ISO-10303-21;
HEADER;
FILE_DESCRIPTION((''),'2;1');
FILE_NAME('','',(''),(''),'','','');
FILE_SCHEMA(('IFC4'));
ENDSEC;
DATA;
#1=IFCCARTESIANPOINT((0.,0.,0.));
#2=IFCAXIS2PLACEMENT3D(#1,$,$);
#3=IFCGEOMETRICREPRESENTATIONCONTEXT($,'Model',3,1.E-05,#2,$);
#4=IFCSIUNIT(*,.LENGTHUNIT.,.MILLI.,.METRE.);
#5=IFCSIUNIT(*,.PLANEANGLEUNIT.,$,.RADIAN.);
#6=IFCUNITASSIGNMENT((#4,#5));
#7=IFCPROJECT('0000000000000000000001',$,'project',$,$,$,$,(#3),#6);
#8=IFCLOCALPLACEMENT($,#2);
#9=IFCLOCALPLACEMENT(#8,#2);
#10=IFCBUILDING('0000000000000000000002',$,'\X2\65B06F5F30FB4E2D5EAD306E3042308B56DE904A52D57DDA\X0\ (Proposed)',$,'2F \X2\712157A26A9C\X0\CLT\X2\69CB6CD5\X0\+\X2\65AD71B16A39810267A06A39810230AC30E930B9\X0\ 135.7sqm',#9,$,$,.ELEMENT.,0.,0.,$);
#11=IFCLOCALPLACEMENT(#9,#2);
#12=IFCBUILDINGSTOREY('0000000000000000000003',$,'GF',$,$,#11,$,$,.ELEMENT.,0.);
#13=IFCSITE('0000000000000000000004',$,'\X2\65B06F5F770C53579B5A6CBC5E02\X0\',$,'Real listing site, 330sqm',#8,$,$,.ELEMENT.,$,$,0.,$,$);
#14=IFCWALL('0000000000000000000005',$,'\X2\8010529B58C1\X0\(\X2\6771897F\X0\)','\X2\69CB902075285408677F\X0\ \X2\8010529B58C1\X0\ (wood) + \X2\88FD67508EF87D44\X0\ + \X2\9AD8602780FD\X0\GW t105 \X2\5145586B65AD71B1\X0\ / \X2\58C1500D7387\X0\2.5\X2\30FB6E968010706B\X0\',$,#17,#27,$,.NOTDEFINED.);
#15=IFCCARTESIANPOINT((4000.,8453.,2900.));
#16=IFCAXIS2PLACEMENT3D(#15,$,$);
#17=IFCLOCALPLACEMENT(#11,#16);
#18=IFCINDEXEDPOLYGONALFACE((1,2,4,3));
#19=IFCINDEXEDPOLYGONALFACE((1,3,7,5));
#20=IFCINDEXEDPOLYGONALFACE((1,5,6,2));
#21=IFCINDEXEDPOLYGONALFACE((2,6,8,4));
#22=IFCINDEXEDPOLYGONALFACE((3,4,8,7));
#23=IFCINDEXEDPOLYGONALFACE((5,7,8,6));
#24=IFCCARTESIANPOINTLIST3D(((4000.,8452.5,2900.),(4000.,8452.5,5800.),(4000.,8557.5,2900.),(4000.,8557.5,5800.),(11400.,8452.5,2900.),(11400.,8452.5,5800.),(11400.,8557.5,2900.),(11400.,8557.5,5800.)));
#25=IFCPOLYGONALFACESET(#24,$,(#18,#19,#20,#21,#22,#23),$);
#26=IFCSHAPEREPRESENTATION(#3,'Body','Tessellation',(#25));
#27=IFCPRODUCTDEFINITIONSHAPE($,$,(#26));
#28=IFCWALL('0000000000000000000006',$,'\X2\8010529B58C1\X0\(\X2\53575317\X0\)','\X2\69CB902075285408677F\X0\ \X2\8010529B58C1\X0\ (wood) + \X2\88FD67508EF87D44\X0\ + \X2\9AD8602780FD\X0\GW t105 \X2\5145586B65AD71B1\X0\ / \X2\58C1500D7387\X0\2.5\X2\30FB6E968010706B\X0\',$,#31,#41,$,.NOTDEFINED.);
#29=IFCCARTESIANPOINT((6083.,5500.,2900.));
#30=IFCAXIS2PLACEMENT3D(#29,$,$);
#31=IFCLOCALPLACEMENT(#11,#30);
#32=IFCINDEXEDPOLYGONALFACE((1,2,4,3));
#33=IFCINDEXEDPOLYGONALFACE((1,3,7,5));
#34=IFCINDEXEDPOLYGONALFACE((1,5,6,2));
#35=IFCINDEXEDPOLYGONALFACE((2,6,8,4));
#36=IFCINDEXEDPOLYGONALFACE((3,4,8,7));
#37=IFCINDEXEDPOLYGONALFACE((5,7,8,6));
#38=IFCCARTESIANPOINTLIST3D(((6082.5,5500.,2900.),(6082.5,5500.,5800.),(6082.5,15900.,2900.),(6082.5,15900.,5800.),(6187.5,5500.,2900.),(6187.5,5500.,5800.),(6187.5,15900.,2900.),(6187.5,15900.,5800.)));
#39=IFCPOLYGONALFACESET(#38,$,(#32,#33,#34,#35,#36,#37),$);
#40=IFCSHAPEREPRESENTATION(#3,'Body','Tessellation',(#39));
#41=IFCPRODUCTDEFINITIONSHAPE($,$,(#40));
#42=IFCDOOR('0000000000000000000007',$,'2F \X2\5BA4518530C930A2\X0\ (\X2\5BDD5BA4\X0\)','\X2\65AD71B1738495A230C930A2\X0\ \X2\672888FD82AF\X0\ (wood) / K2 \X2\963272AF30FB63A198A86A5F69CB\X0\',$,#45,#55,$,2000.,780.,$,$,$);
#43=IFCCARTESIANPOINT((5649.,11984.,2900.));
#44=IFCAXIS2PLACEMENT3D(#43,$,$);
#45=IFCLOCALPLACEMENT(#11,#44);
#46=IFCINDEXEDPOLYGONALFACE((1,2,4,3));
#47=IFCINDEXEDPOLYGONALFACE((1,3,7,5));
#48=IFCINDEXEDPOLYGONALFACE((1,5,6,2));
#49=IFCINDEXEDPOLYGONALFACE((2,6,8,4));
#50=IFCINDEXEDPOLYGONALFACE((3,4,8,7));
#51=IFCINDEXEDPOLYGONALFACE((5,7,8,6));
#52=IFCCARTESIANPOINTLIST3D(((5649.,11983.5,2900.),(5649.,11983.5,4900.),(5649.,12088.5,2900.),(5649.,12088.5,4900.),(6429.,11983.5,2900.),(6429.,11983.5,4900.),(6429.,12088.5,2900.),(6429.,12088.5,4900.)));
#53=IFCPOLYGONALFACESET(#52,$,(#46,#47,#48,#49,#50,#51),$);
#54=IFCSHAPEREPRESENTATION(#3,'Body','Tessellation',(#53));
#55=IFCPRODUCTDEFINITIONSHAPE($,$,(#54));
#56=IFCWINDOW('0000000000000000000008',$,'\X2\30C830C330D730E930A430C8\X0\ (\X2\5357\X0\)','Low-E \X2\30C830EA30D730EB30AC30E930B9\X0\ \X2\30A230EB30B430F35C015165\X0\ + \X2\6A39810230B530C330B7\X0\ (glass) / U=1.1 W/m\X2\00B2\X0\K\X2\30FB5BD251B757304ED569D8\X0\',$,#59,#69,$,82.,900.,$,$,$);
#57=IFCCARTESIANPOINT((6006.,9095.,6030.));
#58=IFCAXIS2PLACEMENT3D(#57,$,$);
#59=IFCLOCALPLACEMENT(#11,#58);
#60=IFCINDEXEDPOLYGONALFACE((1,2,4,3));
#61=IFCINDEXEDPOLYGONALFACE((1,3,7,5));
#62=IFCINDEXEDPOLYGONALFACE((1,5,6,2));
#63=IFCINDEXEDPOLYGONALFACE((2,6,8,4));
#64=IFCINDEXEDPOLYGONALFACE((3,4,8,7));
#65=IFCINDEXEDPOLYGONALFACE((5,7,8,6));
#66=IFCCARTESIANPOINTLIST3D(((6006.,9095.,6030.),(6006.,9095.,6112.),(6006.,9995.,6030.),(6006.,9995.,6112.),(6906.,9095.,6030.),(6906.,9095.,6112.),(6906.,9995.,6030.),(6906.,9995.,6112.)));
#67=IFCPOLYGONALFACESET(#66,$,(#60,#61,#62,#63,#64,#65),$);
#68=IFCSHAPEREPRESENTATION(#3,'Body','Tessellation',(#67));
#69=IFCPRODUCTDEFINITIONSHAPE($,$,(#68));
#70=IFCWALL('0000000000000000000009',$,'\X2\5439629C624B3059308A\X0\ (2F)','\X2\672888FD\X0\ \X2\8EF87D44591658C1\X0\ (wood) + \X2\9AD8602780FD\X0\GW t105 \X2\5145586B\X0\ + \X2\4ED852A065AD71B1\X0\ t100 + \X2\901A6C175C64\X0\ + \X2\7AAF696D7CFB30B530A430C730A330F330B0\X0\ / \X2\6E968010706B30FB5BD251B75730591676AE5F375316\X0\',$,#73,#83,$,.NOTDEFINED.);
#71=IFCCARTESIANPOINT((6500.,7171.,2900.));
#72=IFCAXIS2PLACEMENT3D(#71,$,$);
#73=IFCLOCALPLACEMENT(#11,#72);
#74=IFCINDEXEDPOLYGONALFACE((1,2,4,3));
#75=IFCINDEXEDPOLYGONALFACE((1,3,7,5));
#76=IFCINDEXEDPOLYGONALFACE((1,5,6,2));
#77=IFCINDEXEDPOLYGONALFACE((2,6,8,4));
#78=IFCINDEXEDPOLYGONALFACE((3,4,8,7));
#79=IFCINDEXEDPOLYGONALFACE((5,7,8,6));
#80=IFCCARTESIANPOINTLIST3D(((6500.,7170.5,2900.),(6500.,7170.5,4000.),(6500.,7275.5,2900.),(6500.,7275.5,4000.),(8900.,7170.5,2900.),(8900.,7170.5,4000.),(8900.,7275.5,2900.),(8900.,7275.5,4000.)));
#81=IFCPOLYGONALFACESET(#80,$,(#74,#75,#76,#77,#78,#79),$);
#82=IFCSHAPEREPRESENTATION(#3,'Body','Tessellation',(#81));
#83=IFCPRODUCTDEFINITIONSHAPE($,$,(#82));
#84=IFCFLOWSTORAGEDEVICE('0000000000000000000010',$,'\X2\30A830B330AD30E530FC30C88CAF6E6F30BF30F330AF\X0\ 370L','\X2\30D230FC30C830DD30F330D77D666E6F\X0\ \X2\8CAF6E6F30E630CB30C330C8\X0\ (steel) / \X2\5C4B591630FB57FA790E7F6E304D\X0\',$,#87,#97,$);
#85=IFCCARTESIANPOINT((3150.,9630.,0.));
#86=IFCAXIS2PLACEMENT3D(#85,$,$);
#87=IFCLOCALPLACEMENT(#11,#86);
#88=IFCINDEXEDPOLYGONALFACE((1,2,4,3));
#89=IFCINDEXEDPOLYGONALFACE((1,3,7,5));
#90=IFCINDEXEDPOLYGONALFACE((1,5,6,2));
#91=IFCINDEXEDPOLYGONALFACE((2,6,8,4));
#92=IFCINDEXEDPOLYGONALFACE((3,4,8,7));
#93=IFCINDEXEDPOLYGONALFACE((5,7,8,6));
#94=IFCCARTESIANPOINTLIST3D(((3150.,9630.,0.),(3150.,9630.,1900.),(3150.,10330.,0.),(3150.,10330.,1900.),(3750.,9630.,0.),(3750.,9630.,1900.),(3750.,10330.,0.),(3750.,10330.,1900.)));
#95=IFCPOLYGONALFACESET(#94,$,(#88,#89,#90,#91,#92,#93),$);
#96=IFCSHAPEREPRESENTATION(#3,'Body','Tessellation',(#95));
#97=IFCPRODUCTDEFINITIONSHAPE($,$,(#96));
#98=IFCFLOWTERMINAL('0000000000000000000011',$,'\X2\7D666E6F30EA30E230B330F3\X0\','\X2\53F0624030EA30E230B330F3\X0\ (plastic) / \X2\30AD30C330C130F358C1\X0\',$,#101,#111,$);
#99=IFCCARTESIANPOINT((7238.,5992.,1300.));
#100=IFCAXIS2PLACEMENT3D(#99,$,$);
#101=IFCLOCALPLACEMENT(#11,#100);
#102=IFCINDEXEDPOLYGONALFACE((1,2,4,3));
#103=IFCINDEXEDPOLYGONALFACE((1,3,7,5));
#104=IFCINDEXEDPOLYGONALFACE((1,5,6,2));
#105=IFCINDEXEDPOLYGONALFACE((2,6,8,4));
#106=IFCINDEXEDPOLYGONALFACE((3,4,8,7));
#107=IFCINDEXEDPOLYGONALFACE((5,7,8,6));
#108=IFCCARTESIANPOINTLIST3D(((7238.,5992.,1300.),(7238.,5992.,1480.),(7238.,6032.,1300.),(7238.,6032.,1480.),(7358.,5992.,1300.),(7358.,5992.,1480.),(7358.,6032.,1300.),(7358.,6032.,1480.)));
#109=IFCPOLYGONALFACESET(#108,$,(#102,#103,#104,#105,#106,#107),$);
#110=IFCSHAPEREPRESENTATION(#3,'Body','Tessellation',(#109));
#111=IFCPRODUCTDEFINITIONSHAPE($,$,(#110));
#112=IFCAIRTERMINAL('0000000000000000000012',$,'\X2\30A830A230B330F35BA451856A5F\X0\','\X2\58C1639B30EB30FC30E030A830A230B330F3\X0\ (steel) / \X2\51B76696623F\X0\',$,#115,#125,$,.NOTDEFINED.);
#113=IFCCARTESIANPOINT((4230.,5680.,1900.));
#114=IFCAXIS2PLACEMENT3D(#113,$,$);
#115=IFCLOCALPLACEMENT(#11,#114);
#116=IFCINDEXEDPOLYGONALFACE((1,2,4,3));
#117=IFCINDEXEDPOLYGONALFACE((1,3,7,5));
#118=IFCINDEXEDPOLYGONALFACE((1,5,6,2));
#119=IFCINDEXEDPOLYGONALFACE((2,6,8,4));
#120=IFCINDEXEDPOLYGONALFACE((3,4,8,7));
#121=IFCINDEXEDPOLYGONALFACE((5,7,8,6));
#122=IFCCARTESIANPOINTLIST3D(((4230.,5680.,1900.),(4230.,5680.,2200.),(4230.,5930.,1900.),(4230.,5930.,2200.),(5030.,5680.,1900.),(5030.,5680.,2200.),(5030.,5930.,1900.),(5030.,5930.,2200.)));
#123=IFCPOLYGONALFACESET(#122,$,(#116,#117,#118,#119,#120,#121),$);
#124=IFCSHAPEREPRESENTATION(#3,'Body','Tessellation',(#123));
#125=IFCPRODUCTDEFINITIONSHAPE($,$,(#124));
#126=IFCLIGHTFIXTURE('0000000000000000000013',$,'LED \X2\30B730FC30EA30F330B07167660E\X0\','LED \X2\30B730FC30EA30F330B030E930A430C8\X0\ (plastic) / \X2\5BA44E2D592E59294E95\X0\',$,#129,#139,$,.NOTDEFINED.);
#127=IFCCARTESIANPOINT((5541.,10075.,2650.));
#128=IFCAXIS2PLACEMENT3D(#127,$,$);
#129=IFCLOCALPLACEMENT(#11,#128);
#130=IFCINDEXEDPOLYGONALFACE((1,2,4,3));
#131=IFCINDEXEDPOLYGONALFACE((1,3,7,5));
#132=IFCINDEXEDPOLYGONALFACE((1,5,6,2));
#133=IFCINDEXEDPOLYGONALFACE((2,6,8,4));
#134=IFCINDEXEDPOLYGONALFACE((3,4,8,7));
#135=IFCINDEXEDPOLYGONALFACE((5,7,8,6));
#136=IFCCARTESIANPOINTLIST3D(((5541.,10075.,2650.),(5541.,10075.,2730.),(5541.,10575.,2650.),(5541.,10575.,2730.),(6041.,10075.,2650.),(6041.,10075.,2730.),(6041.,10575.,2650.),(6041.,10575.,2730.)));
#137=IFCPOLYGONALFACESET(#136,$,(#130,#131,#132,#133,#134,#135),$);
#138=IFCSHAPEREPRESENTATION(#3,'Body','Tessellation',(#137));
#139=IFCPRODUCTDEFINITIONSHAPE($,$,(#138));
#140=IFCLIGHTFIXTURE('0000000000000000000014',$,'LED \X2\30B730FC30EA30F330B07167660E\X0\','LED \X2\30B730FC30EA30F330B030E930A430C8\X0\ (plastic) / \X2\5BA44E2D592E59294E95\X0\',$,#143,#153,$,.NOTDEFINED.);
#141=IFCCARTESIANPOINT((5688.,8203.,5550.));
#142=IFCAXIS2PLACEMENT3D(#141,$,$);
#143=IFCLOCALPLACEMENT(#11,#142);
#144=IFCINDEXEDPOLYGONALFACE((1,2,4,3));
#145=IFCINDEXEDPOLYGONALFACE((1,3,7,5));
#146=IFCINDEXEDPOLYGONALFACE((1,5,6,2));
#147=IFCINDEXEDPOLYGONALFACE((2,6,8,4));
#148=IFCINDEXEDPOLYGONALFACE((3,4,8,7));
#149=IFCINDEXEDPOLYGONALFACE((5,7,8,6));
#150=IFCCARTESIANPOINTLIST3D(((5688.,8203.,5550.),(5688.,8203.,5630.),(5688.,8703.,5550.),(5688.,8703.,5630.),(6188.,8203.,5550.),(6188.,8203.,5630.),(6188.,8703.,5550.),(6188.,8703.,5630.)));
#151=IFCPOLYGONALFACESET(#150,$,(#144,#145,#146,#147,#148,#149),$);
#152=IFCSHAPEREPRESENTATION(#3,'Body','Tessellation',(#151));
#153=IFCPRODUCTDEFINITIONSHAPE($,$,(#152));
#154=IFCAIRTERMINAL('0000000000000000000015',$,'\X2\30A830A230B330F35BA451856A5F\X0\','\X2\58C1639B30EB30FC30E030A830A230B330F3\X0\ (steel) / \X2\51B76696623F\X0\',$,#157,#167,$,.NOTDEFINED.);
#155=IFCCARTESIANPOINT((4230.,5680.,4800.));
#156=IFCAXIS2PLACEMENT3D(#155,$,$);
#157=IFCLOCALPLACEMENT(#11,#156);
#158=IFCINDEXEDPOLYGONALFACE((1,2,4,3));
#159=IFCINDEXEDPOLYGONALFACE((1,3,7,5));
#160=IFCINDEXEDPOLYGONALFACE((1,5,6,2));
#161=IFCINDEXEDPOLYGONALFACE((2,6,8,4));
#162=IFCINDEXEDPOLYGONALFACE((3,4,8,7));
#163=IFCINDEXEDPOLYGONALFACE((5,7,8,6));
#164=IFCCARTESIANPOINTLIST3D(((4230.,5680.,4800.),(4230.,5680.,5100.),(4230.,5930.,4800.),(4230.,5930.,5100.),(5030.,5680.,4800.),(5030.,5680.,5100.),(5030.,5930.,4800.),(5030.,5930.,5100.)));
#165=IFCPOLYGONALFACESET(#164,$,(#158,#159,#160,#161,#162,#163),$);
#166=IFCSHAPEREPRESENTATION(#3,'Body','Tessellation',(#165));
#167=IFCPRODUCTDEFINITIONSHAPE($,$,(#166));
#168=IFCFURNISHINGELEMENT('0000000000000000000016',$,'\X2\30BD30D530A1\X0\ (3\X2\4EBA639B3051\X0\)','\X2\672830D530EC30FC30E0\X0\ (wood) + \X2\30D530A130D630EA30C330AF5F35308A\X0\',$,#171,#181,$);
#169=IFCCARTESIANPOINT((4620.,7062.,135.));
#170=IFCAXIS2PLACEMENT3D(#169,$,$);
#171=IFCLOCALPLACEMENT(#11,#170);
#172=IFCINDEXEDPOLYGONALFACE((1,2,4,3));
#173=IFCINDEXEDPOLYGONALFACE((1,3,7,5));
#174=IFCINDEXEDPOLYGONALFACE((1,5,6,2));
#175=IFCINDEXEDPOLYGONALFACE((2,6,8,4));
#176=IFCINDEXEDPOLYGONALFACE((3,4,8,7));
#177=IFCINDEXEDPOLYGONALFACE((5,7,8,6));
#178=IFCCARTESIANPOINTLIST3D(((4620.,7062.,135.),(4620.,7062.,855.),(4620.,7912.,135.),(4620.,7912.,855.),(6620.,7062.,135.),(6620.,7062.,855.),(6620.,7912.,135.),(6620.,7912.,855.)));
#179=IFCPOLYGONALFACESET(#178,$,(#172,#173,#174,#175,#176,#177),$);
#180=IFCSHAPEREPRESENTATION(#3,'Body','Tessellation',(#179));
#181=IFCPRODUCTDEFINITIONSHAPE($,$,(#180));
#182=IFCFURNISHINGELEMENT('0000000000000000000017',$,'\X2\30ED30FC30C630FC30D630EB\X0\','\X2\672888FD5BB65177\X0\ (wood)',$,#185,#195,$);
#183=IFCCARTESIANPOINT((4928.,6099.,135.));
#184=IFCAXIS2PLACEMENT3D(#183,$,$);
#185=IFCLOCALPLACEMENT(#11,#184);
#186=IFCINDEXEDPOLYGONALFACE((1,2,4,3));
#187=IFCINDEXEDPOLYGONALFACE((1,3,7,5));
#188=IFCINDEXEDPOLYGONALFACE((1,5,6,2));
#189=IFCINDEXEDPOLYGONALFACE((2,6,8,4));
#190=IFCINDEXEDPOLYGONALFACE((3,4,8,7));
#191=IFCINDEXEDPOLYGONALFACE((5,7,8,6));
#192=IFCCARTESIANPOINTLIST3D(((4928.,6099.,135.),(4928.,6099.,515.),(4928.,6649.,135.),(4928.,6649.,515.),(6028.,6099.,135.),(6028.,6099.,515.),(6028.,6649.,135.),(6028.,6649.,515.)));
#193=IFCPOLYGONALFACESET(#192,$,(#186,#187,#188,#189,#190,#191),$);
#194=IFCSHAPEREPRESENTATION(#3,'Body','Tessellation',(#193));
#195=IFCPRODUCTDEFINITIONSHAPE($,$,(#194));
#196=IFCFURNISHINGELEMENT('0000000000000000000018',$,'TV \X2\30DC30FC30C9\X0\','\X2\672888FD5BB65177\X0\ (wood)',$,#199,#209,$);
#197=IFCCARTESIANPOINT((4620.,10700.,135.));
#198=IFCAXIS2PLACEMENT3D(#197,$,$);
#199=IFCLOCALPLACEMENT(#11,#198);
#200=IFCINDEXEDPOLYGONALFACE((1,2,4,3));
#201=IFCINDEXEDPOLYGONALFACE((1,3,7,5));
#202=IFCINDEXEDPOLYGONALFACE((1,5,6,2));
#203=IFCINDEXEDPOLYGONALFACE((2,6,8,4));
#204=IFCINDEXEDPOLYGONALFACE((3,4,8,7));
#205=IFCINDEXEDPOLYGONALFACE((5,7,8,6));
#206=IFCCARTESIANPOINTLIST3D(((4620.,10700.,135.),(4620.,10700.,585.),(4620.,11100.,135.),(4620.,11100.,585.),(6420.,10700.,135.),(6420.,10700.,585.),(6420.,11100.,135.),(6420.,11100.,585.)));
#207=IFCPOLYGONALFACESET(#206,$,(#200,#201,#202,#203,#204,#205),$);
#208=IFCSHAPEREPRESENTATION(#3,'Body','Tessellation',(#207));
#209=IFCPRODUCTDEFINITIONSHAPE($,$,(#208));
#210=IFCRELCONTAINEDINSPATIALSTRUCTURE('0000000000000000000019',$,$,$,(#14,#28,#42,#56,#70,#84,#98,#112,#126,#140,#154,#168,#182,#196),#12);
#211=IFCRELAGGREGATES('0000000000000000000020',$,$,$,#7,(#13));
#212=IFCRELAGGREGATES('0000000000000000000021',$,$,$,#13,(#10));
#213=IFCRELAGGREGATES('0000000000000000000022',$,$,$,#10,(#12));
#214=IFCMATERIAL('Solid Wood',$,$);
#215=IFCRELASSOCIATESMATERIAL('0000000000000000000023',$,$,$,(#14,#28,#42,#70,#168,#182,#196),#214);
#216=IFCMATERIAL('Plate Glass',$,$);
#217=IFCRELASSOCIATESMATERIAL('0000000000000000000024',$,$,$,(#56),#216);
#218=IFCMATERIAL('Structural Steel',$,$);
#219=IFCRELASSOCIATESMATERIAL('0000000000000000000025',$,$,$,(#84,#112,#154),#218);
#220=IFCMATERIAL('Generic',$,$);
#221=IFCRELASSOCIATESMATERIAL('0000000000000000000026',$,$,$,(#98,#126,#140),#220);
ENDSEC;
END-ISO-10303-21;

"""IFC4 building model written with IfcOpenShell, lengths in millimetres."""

from ifc_helpers import new_model, si_unit, frame, frame_2d, origin, place, context, project, spatial, rectangle, extrude, material, element, fill, save


model = new_model("IFC4")

# Units and contexts
model_context = context("Model", 3, precision=1e-05, world=origin())
ifc_project = project(units=[si_unit("LENGTHUNIT", "METRE", prefix="MILLI"), si_unit("PLANEANGLEUNIT", "RADIAN")], contexts=[model_context])

# Site, building, storey
site_placement = place(None, origin())
site = spatial("IfcSite", under=ifc_project, at=site_placement, Name="新潟県南魚沼市", ObjectType="Real listing site, 330sqm", CompositionType="ELEMENT", RefElevation=0.0)
building_placement = place(site_placement, origin())
building = spatial("IfcBuilding", under=site, at=building_placement, Name="新潟・中庭のある回遊動線 (Proposed)", ObjectType="2F 無垢檜CLT構法+断熱樹脂枠樹脂ガラス 135.7sqm", CompositionType="ELEMENT", ElevationOfRefHeight=0.0, ElevationOfTerrain=0.0)
storey_placement = place(building_placement, origin())
storey = spatial("IfcBuildingStorey", under=building, at=storey_placement, Name="GF", CompositionType="ELEMENT", Elevation=0.0)

# Shared definitions
ifc_material_1 = material(Name="Solid Wood")

# Wall
wall_1_placement = place(storey_placement, frame((4000.0, 8453.0, 2900.0)))
element("IfcWall", 1, at=wall_1_placement, inside=storey, material=ifc_material_1, Name="耐力壁(東西)", Description="構造用合板 耐力壁 (wood) + 製材軸組 + 高性能GW t105 充填断熱 / 壁倍率2.5・準耐火", PredefinedType="NOTDEFINED", context=model_context, shape_type="SweptSolid", body=[
    extrude(rectangle(XDim=7400.0, YDim=105.0, at=frame_2d((3700.0, 52.0))), frame((4000.0, 8453.0, 2900.0)), (0.0, 0.0, 1.0), 2900.0),
])

# Wall, opening, door
wall_2_placement = place(storey_placement, frame((6083.0, 5500.0, 2900.0)))
wall_2 = element("IfcWall", 2, at=wall_2_placement, inside=storey, material=ifc_material_1, Name="耐力壁(南北)", Description="構造用合板 耐力壁 (wood) + 製材軸組 + 高性能GW t105 充填断熱 / 壁倍率2.5・準耐火", PredefinedType="NOTDEFINED", context=model_context, shape_type="SweptSolid", body=[
    extrude(rectangle(XDim=105.0, YDim=10400.0, at=frame_2d((52.0, 5200.0))), frame((6083.0, 5500.0, 2900.0)), (0.0, 0.0, 1.0), 2900.0),
])
opening_placement = place(storey_placement, frame((5649.0, 11984.0, 2900.0)))
opening = element("IfcOpeningElement", 3, at=opening_placement, cuts=wall_2, PredefinedType="NOTDEFINED", context=model_context, shape_type="SweptSolid", body=[
    extrude(rectangle(XDim=780.0, YDim=105.0, at=frame_2d((390.0, 52.0))), frame((5649.0, 11984.0, 2900.0)), (0.0, 0.0, 1.0), 2000.0),
])
door_placement = place(storey_placement, frame((5649.0, 11984.0, 2900.0)))
door = element("IfcDoor", 4, at=door_placement, inside=storey, material=ifc_material_1, Name="2F 室内ドア (寝室)", Description="断熱玄関ドア 木製芯 (wood) / K2 防犯・採風機構", OverallHeight=2000.0, OverallWidth=780.0, context=model_context, shape_type="SweptSolid", body=[
    extrude(rectangle(XDim=780.0, YDim=105.0, at=frame_2d((390.0, 52.0))), frame((5649.0, 11984.0, 2900.0)), (0.0, 0.0, 1.0), 2000.0),
])
fill(opening, door)

# Window
ifc_material_2 = material(Name="Plate Glass")
window_placement = place(storey_placement, frame((6006.0, 9095.0, 6030.0)))
element("IfcWindow", 5, at=window_placement, inside=storey, material=ifc_material_2, Name="トップライト (南)", Description="Low-E トリプルガラス アルゴン封入 + 樹脂サッシ (glass) / U=1.1 W/m²K・寒冷地仕様", OverallHeight=82.0, OverallWidth=900.0, context=model_context, shape_type="SweptSolid", body=[
    extrude(rectangle(XDim=900.0, YDim=900.0, at=frame_2d((450.0, 450.0))), frame((6006.0, 9095.0, 6030.0)), (0.0, 0.0, 1.0), 82.0),
])

# Wall
wall_3_placement = place(storey_placement, frame((6500.0, 7171.0, 2900.0)))
element("IfcWall", 6, at=wall_3_placement, inside=storey, material=ifc_material_1, Name="吹抜手すり (2F)", Description="木製 軸組外壁 (wood) + 高性能GW t105 充填 + 付加断熱 t100 + 通気層 + 窯業系サイディング / 準耐火・寒冷地外皮強化", PredefinedType="NOTDEFINED", context=model_context, shape_type="SweptSolid", body=[
    extrude(rectangle(XDim=2400.0, YDim=105.0, at=frame_2d((1200.0, 52.0))), frame((6500.0, 7171.0, 2900.0)), (0.0, 0.0, 1.0), 1100.0),
])

# Flow storage device
ifc_material_3 = material(Name="Structural Steel")
flow_storage_device_placement = place(storey_placement, frame((3150.0, 9630.0, 0.0)))
element("IfcFlowStorageDevice", 7, at=flow_storage_device_placement, inside=storey, material=ifc_material_3, Name="エコキュート貯湯タンク 370L", Description="ヒートポンプ給湯 貯湯ユニット (steel) / 屋外・基礎置き", context=model_context, shape_type="SweptSolid", body=[
    extrude(rectangle(XDim=600.0, YDim=700.0, at=frame_2d((300.0, 350.0))), frame((3150.0, 9630.0, 0.0)), (0.0, 0.0, 1.0), 1900.0),
])

# Flow terminal
ifc_material_4 = material(Name="Generic")
flow_terminal_placement = place(storey_placement, frame((7238.0, 5992.0, 1300.0)))
element("IfcFlowTerminal", 8, at=flow_terminal_placement, inside=storey, material=ifc_material_4, Name="給湯リモコン", Description="台所リモコン (plastic) / キッチン壁", context=model_context, shape_type="SweptSolid", body=[
    extrude(rectangle(XDim=120.0, YDim=40.0, at=frame_2d((60.0, 20.0))), frame((7238.0, 5992.0, 1300.0)), (0.0, 0.0, 1.0), 180.0),
])

# Air terminal
air_terminal_1_placement = place(storey_placement, frame((4230.0, 5680.0, 1900.0)))
element("IfcAirTerminal", 9, at=air_terminal_1_placement, inside=storey, material=ifc_material_3, Name="エアコン室内機", Description="壁掛ルームエアコン (steel) / 冷暖房", PredefinedType="NOTDEFINED", context=model_context, shape_type="SweptSolid", body=[
    extrude(rectangle(XDim=800.0, YDim=250.0, at=frame_2d((400.0, 125.0))), frame((4230.0, 5680.0, 1900.0)), (0.0, 0.0, 1.0), 300.0),
])

# Light fixtures
light_fixture_1_placement = place(storey_placement, frame((5541.0, 10075.0, 2650.0)))
element("IfcLightFixture", 10, at=light_fixture_1_placement, inside=storey, material=ifc_material_4, Name="LED シーリング照明", Description="LED シーリングライト (plastic) / 室中央天井", PredefinedType="NOTDEFINED", context=model_context, shape_type="SweptSolid", body=[
    extrude(rectangle(XDim=500.0, YDim=500.0, at=frame_2d((250.0, 250.0))), frame((5541.0, 10075.0, 2650.0)), (0.0, 0.0, 1.0), 80.0),
])
light_fixture_2_placement = place(storey_placement, frame((5688.0, 8203.0, 5550.0)))
element("IfcLightFixture", 11, at=light_fixture_2_placement, inside=storey, material=ifc_material_4, Name="LED シーリング照明", Description="LED シーリングライト (plastic) / 室中央天井", PredefinedType="NOTDEFINED", context=model_context, shape_type="SweptSolid", body=[
    extrude(rectangle(XDim=500.0, YDim=500.0, at=frame_2d((250.0, 250.0))), frame((5688.0, 8203.0, 5550.0)), (0.0, 0.0, 1.0), 80.0),
])

# Air terminal
air_terminal_2_placement = place(storey_placement, frame((4230.0, 5680.0, 4800.0)))
element("IfcAirTerminal", 12, at=air_terminal_2_placement, inside=storey, material=ifc_material_3, Name="エアコン室内機", Description="壁掛ルームエアコン (steel) / 冷暖房", PredefinedType="NOTDEFINED", context=model_context, shape_type="SweptSolid", body=[
    extrude(rectangle(XDim=800.0, YDim=250.0, at=frame_2d((400.0, 125.0))), frame((4230.0, 5680.0, 4800.0)), (0.0, 0.0, 1.0), 300.0),
])

# Furnishing elements
furnishing_1_placement = place(storey_placement, frame((4620.0, 7062.0, 135.0)))
element("IfcFurnishingElement", 13, at=furnishing_1_placement, inside=storey, material=ifc_material_1, Name="ソファ (3人掛け)", Description="木フレーム (wood) + ファブリック張り", context=model_context, shape_type="SweptSolid", body=[
    extrude(rectangle(XDim=2000.0, YDim=850.0, at=frame_2d((1000.0, 425.0))), frame((4620.0, 7062.0, 135.0)), (0.0, 0.0, 1.0), 720.0),
])
furnishing_2_placement = place(storey_placement, frame((4928.0, 6099.0, 135.0)))
element("IfcFurnishingElement", 14, at=furnishing_2_placement, inside=storey, material=ifc_material_1, Name="ローテーブル", Description="木製家具 (wood)", context=model_context, shape_type="SweptSolid", body=[
    extrude(rectangle(XDim=1100.0, YDim=550.0, at=frame_2d((550.0, 275.0))), frame((4928.0, 6099.0, 135.0)), (0.0, 0.0, 1.0), 380.0),
])
furnishing_3_placement = place(storey_placement, frame((4620.0, 10700.0, 135.0)))
element("IfcFurnishingElement", 15, at=furnishing_3_placement, inside=storey, material=ifc_material_1, Name="TV ボード", Description="木製家具 (wood)", context=model_context, shape_type="SweptSolid", body=[
    extrude(rectangle(XDim=1800.0, YDim=400.0, at=frame_2d((900.0, 200.0))), frame((4620.0, 10700.0, 135.0)), (0.0, 0.0, 1.0), 450.0),
])

save(model, "model.ifc")
